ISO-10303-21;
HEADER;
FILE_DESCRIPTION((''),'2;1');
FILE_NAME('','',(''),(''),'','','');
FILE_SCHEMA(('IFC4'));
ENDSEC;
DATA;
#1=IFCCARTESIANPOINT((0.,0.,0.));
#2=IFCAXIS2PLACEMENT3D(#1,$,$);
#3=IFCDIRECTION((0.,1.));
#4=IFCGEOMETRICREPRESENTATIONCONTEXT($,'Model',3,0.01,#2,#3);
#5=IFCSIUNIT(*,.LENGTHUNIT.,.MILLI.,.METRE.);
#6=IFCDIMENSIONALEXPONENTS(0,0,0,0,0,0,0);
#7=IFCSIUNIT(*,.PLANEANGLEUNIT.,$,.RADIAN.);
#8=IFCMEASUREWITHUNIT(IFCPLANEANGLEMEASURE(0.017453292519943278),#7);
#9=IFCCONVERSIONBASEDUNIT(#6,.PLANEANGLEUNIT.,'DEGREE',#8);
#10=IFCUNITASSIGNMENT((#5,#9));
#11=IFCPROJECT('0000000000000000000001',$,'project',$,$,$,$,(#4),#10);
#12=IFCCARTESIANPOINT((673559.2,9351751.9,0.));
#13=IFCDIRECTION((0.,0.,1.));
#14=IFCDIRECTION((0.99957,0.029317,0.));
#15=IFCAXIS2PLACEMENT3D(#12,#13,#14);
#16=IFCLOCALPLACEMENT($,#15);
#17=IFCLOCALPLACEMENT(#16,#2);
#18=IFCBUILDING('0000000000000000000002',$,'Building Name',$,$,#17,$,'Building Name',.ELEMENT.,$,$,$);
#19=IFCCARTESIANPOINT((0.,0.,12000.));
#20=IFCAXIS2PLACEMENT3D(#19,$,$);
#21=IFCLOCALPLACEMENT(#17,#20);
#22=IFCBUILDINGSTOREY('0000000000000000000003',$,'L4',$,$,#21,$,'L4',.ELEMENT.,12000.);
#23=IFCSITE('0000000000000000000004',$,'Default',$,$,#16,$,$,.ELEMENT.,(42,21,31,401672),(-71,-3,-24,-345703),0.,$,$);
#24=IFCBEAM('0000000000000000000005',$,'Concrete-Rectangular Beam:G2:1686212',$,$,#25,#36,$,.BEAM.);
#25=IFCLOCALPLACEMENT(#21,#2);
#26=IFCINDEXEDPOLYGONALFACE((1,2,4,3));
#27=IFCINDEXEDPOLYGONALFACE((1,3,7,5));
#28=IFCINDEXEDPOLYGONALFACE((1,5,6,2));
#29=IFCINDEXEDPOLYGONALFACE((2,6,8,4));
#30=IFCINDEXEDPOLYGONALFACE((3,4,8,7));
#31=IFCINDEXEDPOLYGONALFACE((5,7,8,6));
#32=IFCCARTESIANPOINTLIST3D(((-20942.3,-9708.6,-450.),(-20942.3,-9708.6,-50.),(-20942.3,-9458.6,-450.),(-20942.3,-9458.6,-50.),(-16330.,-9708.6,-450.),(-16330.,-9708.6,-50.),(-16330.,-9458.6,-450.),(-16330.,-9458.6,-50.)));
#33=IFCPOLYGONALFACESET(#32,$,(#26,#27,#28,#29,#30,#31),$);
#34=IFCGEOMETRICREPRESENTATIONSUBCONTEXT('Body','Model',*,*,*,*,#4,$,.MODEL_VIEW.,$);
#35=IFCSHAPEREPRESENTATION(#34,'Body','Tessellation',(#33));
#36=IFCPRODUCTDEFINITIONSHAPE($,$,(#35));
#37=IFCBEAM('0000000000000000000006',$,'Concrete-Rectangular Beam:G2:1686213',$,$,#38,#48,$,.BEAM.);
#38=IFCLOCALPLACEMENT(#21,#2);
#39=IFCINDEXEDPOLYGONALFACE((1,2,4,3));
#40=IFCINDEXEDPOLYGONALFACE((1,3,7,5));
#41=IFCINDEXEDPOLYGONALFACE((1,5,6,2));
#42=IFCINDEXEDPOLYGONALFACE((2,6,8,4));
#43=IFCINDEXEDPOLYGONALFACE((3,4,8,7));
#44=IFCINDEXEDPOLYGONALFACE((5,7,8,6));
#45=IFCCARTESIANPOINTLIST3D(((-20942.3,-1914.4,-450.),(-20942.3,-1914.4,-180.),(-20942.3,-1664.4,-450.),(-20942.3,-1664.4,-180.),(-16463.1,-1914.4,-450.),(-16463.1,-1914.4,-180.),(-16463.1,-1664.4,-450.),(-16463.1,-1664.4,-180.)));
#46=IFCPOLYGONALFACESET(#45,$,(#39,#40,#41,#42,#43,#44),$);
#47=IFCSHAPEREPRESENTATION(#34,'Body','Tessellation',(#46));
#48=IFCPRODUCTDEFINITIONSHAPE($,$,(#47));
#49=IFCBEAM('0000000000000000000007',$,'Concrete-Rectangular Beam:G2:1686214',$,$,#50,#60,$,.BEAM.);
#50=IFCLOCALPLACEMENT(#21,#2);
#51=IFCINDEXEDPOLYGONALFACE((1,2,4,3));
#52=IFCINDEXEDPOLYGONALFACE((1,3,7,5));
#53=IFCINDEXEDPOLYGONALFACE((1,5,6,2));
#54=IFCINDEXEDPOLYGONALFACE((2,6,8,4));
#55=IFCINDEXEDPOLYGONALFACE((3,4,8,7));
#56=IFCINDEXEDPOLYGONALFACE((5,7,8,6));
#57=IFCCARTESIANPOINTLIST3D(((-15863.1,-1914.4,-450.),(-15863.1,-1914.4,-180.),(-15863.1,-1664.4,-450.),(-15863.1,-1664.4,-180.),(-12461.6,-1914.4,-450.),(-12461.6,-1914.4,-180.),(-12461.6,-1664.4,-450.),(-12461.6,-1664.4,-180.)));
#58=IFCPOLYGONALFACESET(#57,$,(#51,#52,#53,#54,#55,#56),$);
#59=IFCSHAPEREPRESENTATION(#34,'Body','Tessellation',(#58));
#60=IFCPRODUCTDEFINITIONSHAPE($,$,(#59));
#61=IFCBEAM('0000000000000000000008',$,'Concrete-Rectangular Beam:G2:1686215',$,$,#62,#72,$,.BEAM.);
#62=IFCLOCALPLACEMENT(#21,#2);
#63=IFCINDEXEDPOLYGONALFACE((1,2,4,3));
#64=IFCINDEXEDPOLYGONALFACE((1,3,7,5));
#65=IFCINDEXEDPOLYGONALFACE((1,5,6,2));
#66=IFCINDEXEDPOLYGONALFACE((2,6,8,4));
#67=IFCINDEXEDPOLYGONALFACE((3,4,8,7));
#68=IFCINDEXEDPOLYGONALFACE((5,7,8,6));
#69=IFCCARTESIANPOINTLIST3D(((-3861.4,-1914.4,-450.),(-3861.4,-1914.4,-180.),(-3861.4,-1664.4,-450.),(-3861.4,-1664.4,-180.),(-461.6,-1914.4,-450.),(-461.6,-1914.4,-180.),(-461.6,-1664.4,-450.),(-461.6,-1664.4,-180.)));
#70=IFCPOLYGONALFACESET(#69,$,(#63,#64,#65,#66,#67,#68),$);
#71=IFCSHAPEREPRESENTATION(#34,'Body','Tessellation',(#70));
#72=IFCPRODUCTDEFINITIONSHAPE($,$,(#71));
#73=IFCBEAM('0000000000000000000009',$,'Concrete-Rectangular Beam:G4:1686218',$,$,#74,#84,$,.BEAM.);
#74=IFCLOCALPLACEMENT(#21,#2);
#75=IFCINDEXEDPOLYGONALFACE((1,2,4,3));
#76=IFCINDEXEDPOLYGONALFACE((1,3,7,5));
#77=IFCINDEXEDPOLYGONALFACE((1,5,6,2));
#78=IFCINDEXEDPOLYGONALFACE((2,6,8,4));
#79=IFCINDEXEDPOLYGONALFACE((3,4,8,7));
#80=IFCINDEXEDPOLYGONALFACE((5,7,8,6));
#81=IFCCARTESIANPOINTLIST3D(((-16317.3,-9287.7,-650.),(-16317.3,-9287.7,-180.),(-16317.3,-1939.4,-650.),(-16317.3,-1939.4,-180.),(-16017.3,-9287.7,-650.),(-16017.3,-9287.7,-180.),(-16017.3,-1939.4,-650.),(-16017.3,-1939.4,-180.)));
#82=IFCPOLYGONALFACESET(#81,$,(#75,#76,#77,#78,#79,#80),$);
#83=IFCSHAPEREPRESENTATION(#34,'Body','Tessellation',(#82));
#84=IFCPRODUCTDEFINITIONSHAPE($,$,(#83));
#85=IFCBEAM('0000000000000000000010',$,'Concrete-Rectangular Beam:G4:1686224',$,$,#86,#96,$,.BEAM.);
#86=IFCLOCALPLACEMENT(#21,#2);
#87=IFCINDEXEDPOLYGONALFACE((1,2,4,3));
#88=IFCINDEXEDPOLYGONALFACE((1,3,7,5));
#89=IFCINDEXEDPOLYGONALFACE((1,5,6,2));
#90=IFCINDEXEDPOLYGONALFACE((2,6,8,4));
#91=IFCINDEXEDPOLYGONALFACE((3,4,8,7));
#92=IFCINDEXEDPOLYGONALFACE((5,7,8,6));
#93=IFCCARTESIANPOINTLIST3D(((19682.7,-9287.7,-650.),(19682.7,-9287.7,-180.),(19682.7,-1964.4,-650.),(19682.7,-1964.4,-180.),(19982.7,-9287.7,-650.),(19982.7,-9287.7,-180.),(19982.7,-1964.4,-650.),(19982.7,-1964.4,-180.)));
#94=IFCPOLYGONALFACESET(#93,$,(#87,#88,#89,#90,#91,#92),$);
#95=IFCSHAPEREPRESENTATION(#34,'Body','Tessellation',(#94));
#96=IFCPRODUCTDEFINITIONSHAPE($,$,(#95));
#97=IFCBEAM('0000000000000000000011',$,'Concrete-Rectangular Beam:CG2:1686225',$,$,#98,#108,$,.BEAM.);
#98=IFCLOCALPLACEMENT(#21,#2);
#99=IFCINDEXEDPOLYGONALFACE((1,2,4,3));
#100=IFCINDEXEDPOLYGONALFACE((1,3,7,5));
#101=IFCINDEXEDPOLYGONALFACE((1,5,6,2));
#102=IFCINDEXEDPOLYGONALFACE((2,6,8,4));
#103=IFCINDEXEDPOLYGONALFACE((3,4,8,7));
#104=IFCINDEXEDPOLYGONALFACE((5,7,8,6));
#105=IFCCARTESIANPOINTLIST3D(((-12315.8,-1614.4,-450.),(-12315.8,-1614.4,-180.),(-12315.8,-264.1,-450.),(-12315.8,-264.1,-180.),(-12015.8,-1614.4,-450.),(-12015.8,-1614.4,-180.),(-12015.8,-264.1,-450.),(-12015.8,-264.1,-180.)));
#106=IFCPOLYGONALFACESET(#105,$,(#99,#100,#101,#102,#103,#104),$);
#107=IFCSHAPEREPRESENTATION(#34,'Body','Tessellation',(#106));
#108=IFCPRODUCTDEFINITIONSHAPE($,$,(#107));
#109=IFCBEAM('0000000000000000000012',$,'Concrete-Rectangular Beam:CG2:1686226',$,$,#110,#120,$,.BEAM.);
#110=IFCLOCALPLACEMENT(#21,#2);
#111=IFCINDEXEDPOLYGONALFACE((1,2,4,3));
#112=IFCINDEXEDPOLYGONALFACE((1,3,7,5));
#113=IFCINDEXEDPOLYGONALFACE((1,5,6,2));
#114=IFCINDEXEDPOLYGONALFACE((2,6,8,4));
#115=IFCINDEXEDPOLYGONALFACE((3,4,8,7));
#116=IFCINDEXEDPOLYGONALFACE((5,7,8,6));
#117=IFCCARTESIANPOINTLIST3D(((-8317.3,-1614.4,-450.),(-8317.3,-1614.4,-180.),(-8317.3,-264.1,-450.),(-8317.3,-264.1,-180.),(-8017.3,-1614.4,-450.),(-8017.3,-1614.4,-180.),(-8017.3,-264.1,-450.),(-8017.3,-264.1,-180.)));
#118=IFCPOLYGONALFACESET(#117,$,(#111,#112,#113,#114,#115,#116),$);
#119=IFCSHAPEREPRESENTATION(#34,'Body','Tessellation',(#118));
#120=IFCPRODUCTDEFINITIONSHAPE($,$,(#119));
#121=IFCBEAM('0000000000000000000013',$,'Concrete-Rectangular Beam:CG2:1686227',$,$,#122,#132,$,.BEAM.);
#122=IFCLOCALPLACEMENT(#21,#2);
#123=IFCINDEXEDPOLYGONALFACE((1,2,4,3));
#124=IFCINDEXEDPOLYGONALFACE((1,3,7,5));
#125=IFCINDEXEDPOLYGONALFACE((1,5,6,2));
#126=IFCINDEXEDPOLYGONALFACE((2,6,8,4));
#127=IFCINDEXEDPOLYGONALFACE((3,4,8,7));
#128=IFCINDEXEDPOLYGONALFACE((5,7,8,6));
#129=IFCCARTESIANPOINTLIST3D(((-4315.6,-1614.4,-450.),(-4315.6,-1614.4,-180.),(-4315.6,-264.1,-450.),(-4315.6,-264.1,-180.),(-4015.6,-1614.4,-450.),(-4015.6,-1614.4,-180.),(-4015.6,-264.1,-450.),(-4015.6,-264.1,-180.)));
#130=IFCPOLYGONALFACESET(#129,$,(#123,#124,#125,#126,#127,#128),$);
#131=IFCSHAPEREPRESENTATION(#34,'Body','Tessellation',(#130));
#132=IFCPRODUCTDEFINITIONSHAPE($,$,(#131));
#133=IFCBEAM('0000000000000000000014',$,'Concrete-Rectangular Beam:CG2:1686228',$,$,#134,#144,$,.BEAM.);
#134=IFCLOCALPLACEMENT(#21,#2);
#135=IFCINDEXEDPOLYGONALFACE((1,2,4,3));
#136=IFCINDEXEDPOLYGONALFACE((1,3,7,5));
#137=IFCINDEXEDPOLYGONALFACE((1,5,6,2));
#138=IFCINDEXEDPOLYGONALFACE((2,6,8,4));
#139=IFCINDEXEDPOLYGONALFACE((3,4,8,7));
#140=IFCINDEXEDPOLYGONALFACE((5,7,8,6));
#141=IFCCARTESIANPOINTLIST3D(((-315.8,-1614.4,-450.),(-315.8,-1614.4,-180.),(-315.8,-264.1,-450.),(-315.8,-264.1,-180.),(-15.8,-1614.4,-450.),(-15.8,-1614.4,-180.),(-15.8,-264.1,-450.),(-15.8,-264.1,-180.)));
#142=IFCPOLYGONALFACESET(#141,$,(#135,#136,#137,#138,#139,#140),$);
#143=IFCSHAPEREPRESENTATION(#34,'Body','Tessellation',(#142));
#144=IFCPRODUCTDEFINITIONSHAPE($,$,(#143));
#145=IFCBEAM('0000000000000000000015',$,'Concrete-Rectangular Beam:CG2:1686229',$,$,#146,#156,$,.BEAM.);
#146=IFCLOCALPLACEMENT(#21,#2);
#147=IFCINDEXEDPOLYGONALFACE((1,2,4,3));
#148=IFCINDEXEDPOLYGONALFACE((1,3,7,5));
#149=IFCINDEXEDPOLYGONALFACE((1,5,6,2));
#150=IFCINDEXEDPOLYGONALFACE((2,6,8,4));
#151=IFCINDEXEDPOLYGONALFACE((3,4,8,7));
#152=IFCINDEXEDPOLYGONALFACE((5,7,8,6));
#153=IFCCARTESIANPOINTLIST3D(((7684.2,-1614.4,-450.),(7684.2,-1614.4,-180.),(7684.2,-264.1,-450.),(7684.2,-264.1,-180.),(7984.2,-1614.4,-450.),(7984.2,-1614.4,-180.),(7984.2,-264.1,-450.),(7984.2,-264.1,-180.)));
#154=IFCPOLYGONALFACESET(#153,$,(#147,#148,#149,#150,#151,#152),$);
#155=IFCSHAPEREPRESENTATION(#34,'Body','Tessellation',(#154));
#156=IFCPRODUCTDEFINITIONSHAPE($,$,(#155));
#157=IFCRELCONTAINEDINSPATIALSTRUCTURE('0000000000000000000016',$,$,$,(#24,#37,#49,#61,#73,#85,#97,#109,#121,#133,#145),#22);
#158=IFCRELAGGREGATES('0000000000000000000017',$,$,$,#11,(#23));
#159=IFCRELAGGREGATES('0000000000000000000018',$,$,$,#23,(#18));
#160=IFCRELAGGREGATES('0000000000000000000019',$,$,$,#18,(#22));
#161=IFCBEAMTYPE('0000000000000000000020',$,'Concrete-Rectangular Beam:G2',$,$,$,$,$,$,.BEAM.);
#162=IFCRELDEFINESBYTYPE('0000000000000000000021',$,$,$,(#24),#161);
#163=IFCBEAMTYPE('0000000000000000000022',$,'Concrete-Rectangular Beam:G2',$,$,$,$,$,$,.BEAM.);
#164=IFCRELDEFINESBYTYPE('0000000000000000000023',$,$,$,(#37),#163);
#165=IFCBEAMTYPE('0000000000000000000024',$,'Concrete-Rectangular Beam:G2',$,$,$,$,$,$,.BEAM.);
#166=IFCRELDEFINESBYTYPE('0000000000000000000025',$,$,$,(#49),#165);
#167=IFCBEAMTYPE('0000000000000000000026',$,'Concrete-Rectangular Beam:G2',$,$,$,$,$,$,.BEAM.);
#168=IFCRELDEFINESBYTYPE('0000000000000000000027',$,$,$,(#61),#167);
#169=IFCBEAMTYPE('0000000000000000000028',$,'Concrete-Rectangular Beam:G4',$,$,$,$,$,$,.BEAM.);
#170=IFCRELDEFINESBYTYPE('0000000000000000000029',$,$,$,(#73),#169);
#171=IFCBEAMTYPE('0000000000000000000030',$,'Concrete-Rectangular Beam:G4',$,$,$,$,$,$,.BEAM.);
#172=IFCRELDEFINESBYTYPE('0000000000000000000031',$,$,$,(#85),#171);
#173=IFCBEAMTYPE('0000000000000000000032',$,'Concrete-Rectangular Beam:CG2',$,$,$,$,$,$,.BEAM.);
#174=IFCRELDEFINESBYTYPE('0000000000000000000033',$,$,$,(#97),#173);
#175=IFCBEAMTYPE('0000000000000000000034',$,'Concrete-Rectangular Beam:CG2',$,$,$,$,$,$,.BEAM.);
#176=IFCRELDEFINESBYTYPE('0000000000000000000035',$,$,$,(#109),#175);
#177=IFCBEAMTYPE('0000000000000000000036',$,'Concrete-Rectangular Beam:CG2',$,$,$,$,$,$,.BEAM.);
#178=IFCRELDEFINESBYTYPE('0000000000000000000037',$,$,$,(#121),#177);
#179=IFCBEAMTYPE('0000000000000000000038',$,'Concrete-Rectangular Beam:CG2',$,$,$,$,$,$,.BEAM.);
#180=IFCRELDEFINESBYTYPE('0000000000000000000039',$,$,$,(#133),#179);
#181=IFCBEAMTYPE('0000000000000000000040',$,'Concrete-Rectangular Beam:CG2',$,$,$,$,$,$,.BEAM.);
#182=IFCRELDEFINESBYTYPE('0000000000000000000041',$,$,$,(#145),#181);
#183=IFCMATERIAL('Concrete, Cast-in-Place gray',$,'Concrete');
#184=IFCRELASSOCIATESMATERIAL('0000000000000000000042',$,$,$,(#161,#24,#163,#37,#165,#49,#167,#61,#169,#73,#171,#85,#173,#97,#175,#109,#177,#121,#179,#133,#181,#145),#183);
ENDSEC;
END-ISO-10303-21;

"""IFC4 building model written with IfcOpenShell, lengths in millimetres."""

from ifc_helpers import new_model, entity, si_unit, converted_unit, direction, frame, origin, place, context, subcontext, project, spatial, indexed_curve, outline, extrude, source, transform, mapped, material, type_object, type_shapes, element, save


model = new_model("IFC4")

# Units and contexts
model_context = context("Model", 3, precision=0.01, world=origin(), true_north=direction((0.0, 1.0)))
body_context = subcontext(model_context, "Body", "Model", "MODEL_VIEW")
ifc_project = project(units=[si_unit("LENGTHUNIT", "METRE", prefix="MILLI"), converted_unit("PLANEANGLEUNIT", "DEGREE", entity("IfcPlaneAngleMeasure", 0.017453292519943278), si_unit("PLANEANGLEUNIT", "RADIAN"), dimensions=[0, 0, 0, 0, 0, 0, 0])], contexts=[model_context])

# Site, building, storey
site_placement = place(None, frame((673559.2, 9351751.9, 0.0), z_axis=(0.0, 0.0, 1.0), x_axis=(0.99957, 0.029317, 0.0)))
site = spatial("IfcSite", under=ifc_project, at=site_placement, Name="Default", CompositionType="ELEMENT", RefLatitude=(42, 21, 31, 401672), RefLongitude=(-71, -3, -24, -345703), RefElevation=0.0)
building_placement = place(site_placement, origin())
building = spatial("IfcBuilding", under=site, at=building_placement, Name="Building Name", LongName="Building Name", CompositionType="ELEMENT")
storey_placement = place(building_placement, frame((0.0, 0.0, 12000.0)))
storey = spatial("IfcBuildingStorey", under=building, at=storey_placement, Name="L4", LongName="L4", CompositionType="ELEMENT", Elevation=12000.0)

# Beams
ifc_material = material(Name="Concrete, Cast-in-Place gray", Category="Concrete")
beam_type_1 = type_object("IfcBeamType", Name="Concrete-Rectangular Beam:G2", PredefinedType="BEAM", material=ifc_material)
shared_shape_1 = source(origin(), body_context, "Body", "SweptSolid", [
    extrude(outline(indexed_curve([(-200.0, -125.0), (200.0, -125.0), (200.0, 125.0), (-200.0, 125.0), (-200.0, -125.0)], self_intersect=False)), frame((-16330.0, -9583.6, 11750.0), z_axis=(-1.0, 0.0, 0.0), x_axis=(0.0, 0.0, -1.0)), (0.0, 0.0, 1.0), 4612.3),
])
type_shapes(beam_type_1, [shared_shape_1])
beam_1_placement = place(storey_placement, frame((0.0, 0.0, -12000.0)))
element("IfcBeam", 1, at=beam_1_placement, inside=storey, type_object=beam_type_1, material=ifc_material, Name="Concrete-Rectangular Beam:G2:1686212", PredefinedType="BEAM", context=body_context, shape_type="MappedRepresentation", body=[
    mapped(shared_shape_1, transform((0.0, 0.0, 0.0), scale=1.0)),
])
beam_type_2 = type_object("IfcBeamType", Name="Concrete-Rectangular Beam:G2", PredefinedType="BEAM", material=ifc_material)
shared_shape_2 = source(origin(), body_context, "Body", "SweptSolid", [
    extrude(outline(indexed_curve([(-135.0, -125.0), (135.0, -125.0), (135.0, 125.0), (-135.0, 125.0), (-135.0, -125.0)], self_intersect=False)), frame((-20942.3, -1789.4, 11685.0), z_axis=(1.0, 0.0, 0.0), x_axis=(0.0, 0.0, -1.0)), (0.0, 0.0, 1.0), 4479.2),
])
type_shapes(beam_type_2, [shared_shape_2])
beam_2_placement = place(storey_placement, frame((0.0, 0.0, -12000.0)))
element("IfcBeam", 2, at=beam_2_placement, inside=storey, type_object=beam_type_2, material=ifc_material, Name="Concrete-Rectangular Beam:G2:1686213", PredefinedType="BEAM", context=body_context, shape_type="MappedRepresentation", body=[
    mapped(shared_shape_2, transform((0.0, 0.0, 0.0), scale=1.0)),
])
beam_type_3 = type_object("IfcBeamType", Name="Concrete-Rectangular Beam:G2", PredefinedType="BEAM", material=ifc_material)
shared_shape_3 = source(origin(), body_context, "Body", "SweptSolid", [
    extrude(outline(indexed_curve([(-135.0, -125.0), (135.0, -125.0), (135.0, 125.0), (-135.0, 125.0), (-135.0, -125.0)], self_intersect=False)), frame((-15863.1, -1789.4, 11685.0), z_axis=(1.0, 0.0, 0.0), x_axis=(0.0, 0.0, -1.0)), (0.0, 0.0, 1.0), 3401.5),
])
type_shapes(beam_type_3, [shared_shape_3])
beam_3_placement = place(storey_placement, frame((0.0, 0.0, -12000.0)))
element("IfcBeam", 3, at=beam_3_placement, inside=storey, type_object=beam_type_3, material=ifc_material, Name="Concrete-Rectangular Beam:G2:1686214", PredefinedType="BEAM", context=body_context, shape_type="MappedRepresentation", body=[
    mapped(shared_shape_3, transform((0.0, 0.0, 0.0), scale=1.0)),
])
beam_type_4 = type_object("IfcBeamType", Name="Concrete-Rectangular Beam:G2", PredefinedType="BEAM", material=ifc_material)
shared_shape_4 = source(origin(), body_context, "Body", "SweptSolid", [
    extrude(outline(indexed_curve([(-135.0, -125.0), (135.0, -125.0), (135.0, 125.0), (-135.0, 125.0), (-135.0, -125.0)], self_intersect=False)), frame((-461.6, -1789.4, 11685.0), z_axis=(-1.0, 0.0, 0.0), x_axis=(0.0, 0.0, -1.0)), (0.0, 0.0, 1.0), 3399.7),
])
type_shapes(beam_type_4, [shared_shape_4])
beam_4_placement = place(storey_placement, frame((0.0, 0.0, -12000.0)))
element("IfcBeam", 4, at=beam_4_placement, inside=storey, type_object=beam_type_4, material=ifc_material, Name="Concrete-Rectangular Beam:G2:1686215", PredefinedType="BEAM", context=body_context, shape_type="MappedRepresentation", body=[
    mapped(shared_shape_4, transform((0.0, 0.0, 0.0), scale=1.0)),
])
beam_type_5 = type_object("IfcBeamType", Name="Concrete-Rectangular Beam:G4", PredefinedType="BEAM", material=ifc_material)
shared_shape_5 = source(origin(), body_context, "Body", "SweptSolid", [
    extrude(outline(indexed_curve([(-150.0, -235.0), (150.0, -235.0), (150.0, 235.0), (-150.0, 235.0), (-150.0, -235.0)], self_intersect=False)), frame((-16167.3, -9287.7, 11585.0), z_axis=(0.0, 1.0, 0.0), x_axis=(-1.0, 0.0, 0.0)), (0.0, 0.0, 1.0), 7348.3),
])
type_shapes(beam_type_5, [shared_shape_5])
beam_5_placement = place(storey_placement, frame((0.0, 0.0, -12000.0)))
element("IfcBeam", 5, at=beam_5_placement, inside=storey, type_object=beam_type_5, material=ifc_material, Name="Concrete-Rectangular Beam:G4:1686218", PredefinedType="BEAM", context=body_context, shape_type="MappedRepresentation", body=[
    mapped(shared_shape_5, transform((0.0, 0.0, 0.0), scale=1.0)),
])
beam_type_6 = type_object("IfcBeamType", Name="Concrete-Rectangular Beam:G4", PredefinedType="BEAM", material=ifc_material)
shared_shape_6 = source(origin(), body_context, "Body", "SweptSolid", [
    extrude(outline(indexed_curve([(-150.0, -235.0), (150.0, -235.0), (150.0, 235.0), (-150.0, 235.0), (-150.0, -235.0)], self_intersect=False)), frame((19832.7, -9287.7, 11585.0), z_axis=(0.0, 1.0, 0.0), x_axis=(-1.0, 0.0, 0.0)), (0.0, 0.0, 1.0), 7323.3),
])
type_shapes(beam_type_6, [shared_shape_6])
beam_6_placement = place(storey_placement, frame((0.0, 0.0, -12000.0)))
element("IfcBeam", 6, at=beam_6_placement, inside=storey, type_object=beam_type_6, material=ifc_material, Name="Concrete-Rectangular Beam:G4:1686224", PredefinedType="BEAM", context=body_context, shape_type="MappedRepresentation", body=[
    mapped(shared_shape_6, transform((0.0, 0.0, 0.0), scale=1.0)),
])
beam_type_7 = type_object("IfcBeamType", Name="Concrete-Rectangular Beam:CG2", PredefinedType="BEAM", material=ifc_material)
shared_shape_7 = source(origin(), body_context, "Body", "SweptSolid", [
    extrude(outline(indexed_curve([(-150.0, -135.0), (150.0, -135.0), (150.0, 135.0), (-150.0, 135.0), (-150.0, -135.0)], self_intersect=False)), frame((-12165.8, -1614.4, 11685.0), z_axis=(0.0, 1.0, 0.0), x_axis=(-1.0, 0.0, 0.0)), (0.0, 0.0, 1.0), 1350.4),
])
type_shapes(beam_type_7, [shared_shape_7])
beam_7_placement = place(storey_placement, frame((0.0, 0.0, -12000.0)))
element("IfcBeam", 7, at=beam_7_placement, inside=storey, type_object=beam_type_7, material=ifc_material, Name="Concrete-Rectangular Beam:CG2:1686225", PredefinedType="BEAM", context=body_context, shape_type="MappedRepresentation", body=[
    mapped(shared_shape_7, transform((0.0, 0.0, 0.0), scale=1.0)),
])
beam_type_8 = type_object("IfcBeamType", Name="Concrete-Rectangular Beam:CG2", PredefinedType="BEAM", material=ifc_material)
shared_shape_8 = source(origin(), body_context, "Body", "SweptSolid", [
    extrude(outline(indexed_curve([(-150.0, -135.0), (150.0, -135.0), (150.0, 135.0), (-150.0, 135.0), (-150.0, -135.0)], self_intersect=False)), frame((-8167.3, -1614.4, 11685.0), z_axis=(0.0, 1.0, 0.0), x_axis=(-1.0, 0.0, 0.0)), (0.0, 0.0, 1.0), 1350.4),
])
type_shapes(beam_type_8, [shared_shape_8])
beam_8_placement = place(storey_placement, frame((0.0, 0.0, -12000.0)))
element("IfcBeam", 8, at=beam_8_placement, inside=storey, type_object=beam_type_8, material=ifc_material, Name="Concrete-Rectangular Beam:CG2:1686226", PredefinedType="BEAM", context=body_context, shape_type="MappedRepresentation", body=[
    mapped(shared_shape_8, transform((0.0, 0.0, 0.0), scale=1.0)),
])
beam_type_9 = type_object("IfcBeamType", Name="Concrete-Rectangular Beam:CG2", PredefinedType="BEAM", material=ifc_material)
shared_shape_9 = source(origin(), body_context, "Body", "SweptSolid", [
    extrude(outline(indexed_curve([(-150.0, -135.0), (150.0, -135.0), (150.0, 135.0), (-150.0, 135.0), (-150.0, -135.0)], self_intersect=False)), frame((-4165.6, -1614.4, 11685.0), z_axis=(0.0, 1.0, 0.0), x_axis=(-1.0, 0.0, 0.0)), (0.0, 0.0, 1.0), 1350.4),
])
type_shapes(beam_type_9, [shared_shape_9])
beam_9_placement = place(storey_placement, frame((0.0, 0.0, -12000.0)))
element("IfcBeam", 9, at=beam_9_placement, inside=storey, type_object=beam_type_9, material=ifc_material, Name="Concrete-Rectangular Beam:CG2:1686227", PredefinedType="BEAM", context=body_context, shape_type="MappedRepresentation", body=[
    mapped(shared_shape_9, transform((0.0, 0.0, 0.0), scale=1.0)),
])
beam_type_10 = type_object("IfcBeamType", Name="Concrete-Rectangular Beam:CG2", PredefinedType="BEAM", material=ifc_material)
shared_shape_10 = source(origin(), body_context, "Body", "SweptSolid", [
    extrude(outline(indexed_curve([(-150.0, -135.0), (150.0, -135.0), (150.0, 135.0), (-150.0, 135.0), (-150.0, -135.0)], self_intersect=False)), frame((-165.8, -1614.4, 11685.0), z_axis=(0.0, 1.0, 0.0), x_axis=(-1.0, 0.0, 0.0)), (0.0, 0.0, 1.0), 1350.4),
])
type_shapes(beam_type_10, [shared_shape_10])
beam_10_placement = place(storey_placement, frame((0.0, 0.0, -12000.0)))
element("IfcBeam", 10, at=beam_10_placement, inside=storey, type_object=beam_type_10, material=ifc_material, Name="Concrete-Rectangular Beam:CG2:1686228", PredefinedType="BEAM", context=body_context, shape_type="MappedRepresentation", body=[
    mapped(shared_shape_10, transform((0.0, 0.0, 0.0), scale=1.0)),
])
beam_type_11 = type_object("IfcBeamType", Name="Concrete-Rectangular Beam:CG2", PredefinedType="BEAM", material=ifc_material)
shared_shape_11 = source(origin(), body_context, "Body", "SweptSolid", [
    extrude(outline(indexed_curve([(-150.0, -135.0), (150.0, -135.0), (150.0, 135.0), (-150.0, 135.0), (-150.0, -135.0)], self_intersect=False)), frame((7834.2, -1614.4, 11685.0), z_axis=(0.0, 1.0, 0.0), x_axis=(-1.0, 0.0, 0.0)), (0.0, 0.0, 1.0), 1350.4),
])
type_shapes(beam_type_11, [shared_shape_11])
beam_11_placement = place(storey_placement, frame((0.0, 0.0, -12000.0)))
element("IfcBeam", 11, at=beam_11_placement, inside=storey, type_object=beam_type_11, material=ifc_material, Name="Concrete-Rectangular Beam:CG2:1686229", PredefinedType="BEAM", context=body_context, shape_type="MappedRepresentation", body=[
    mapped(shared_shape_11, transform((0.0, 0.0, 0.0), scale=1.0)),
])

save(model, "model.ifc")
